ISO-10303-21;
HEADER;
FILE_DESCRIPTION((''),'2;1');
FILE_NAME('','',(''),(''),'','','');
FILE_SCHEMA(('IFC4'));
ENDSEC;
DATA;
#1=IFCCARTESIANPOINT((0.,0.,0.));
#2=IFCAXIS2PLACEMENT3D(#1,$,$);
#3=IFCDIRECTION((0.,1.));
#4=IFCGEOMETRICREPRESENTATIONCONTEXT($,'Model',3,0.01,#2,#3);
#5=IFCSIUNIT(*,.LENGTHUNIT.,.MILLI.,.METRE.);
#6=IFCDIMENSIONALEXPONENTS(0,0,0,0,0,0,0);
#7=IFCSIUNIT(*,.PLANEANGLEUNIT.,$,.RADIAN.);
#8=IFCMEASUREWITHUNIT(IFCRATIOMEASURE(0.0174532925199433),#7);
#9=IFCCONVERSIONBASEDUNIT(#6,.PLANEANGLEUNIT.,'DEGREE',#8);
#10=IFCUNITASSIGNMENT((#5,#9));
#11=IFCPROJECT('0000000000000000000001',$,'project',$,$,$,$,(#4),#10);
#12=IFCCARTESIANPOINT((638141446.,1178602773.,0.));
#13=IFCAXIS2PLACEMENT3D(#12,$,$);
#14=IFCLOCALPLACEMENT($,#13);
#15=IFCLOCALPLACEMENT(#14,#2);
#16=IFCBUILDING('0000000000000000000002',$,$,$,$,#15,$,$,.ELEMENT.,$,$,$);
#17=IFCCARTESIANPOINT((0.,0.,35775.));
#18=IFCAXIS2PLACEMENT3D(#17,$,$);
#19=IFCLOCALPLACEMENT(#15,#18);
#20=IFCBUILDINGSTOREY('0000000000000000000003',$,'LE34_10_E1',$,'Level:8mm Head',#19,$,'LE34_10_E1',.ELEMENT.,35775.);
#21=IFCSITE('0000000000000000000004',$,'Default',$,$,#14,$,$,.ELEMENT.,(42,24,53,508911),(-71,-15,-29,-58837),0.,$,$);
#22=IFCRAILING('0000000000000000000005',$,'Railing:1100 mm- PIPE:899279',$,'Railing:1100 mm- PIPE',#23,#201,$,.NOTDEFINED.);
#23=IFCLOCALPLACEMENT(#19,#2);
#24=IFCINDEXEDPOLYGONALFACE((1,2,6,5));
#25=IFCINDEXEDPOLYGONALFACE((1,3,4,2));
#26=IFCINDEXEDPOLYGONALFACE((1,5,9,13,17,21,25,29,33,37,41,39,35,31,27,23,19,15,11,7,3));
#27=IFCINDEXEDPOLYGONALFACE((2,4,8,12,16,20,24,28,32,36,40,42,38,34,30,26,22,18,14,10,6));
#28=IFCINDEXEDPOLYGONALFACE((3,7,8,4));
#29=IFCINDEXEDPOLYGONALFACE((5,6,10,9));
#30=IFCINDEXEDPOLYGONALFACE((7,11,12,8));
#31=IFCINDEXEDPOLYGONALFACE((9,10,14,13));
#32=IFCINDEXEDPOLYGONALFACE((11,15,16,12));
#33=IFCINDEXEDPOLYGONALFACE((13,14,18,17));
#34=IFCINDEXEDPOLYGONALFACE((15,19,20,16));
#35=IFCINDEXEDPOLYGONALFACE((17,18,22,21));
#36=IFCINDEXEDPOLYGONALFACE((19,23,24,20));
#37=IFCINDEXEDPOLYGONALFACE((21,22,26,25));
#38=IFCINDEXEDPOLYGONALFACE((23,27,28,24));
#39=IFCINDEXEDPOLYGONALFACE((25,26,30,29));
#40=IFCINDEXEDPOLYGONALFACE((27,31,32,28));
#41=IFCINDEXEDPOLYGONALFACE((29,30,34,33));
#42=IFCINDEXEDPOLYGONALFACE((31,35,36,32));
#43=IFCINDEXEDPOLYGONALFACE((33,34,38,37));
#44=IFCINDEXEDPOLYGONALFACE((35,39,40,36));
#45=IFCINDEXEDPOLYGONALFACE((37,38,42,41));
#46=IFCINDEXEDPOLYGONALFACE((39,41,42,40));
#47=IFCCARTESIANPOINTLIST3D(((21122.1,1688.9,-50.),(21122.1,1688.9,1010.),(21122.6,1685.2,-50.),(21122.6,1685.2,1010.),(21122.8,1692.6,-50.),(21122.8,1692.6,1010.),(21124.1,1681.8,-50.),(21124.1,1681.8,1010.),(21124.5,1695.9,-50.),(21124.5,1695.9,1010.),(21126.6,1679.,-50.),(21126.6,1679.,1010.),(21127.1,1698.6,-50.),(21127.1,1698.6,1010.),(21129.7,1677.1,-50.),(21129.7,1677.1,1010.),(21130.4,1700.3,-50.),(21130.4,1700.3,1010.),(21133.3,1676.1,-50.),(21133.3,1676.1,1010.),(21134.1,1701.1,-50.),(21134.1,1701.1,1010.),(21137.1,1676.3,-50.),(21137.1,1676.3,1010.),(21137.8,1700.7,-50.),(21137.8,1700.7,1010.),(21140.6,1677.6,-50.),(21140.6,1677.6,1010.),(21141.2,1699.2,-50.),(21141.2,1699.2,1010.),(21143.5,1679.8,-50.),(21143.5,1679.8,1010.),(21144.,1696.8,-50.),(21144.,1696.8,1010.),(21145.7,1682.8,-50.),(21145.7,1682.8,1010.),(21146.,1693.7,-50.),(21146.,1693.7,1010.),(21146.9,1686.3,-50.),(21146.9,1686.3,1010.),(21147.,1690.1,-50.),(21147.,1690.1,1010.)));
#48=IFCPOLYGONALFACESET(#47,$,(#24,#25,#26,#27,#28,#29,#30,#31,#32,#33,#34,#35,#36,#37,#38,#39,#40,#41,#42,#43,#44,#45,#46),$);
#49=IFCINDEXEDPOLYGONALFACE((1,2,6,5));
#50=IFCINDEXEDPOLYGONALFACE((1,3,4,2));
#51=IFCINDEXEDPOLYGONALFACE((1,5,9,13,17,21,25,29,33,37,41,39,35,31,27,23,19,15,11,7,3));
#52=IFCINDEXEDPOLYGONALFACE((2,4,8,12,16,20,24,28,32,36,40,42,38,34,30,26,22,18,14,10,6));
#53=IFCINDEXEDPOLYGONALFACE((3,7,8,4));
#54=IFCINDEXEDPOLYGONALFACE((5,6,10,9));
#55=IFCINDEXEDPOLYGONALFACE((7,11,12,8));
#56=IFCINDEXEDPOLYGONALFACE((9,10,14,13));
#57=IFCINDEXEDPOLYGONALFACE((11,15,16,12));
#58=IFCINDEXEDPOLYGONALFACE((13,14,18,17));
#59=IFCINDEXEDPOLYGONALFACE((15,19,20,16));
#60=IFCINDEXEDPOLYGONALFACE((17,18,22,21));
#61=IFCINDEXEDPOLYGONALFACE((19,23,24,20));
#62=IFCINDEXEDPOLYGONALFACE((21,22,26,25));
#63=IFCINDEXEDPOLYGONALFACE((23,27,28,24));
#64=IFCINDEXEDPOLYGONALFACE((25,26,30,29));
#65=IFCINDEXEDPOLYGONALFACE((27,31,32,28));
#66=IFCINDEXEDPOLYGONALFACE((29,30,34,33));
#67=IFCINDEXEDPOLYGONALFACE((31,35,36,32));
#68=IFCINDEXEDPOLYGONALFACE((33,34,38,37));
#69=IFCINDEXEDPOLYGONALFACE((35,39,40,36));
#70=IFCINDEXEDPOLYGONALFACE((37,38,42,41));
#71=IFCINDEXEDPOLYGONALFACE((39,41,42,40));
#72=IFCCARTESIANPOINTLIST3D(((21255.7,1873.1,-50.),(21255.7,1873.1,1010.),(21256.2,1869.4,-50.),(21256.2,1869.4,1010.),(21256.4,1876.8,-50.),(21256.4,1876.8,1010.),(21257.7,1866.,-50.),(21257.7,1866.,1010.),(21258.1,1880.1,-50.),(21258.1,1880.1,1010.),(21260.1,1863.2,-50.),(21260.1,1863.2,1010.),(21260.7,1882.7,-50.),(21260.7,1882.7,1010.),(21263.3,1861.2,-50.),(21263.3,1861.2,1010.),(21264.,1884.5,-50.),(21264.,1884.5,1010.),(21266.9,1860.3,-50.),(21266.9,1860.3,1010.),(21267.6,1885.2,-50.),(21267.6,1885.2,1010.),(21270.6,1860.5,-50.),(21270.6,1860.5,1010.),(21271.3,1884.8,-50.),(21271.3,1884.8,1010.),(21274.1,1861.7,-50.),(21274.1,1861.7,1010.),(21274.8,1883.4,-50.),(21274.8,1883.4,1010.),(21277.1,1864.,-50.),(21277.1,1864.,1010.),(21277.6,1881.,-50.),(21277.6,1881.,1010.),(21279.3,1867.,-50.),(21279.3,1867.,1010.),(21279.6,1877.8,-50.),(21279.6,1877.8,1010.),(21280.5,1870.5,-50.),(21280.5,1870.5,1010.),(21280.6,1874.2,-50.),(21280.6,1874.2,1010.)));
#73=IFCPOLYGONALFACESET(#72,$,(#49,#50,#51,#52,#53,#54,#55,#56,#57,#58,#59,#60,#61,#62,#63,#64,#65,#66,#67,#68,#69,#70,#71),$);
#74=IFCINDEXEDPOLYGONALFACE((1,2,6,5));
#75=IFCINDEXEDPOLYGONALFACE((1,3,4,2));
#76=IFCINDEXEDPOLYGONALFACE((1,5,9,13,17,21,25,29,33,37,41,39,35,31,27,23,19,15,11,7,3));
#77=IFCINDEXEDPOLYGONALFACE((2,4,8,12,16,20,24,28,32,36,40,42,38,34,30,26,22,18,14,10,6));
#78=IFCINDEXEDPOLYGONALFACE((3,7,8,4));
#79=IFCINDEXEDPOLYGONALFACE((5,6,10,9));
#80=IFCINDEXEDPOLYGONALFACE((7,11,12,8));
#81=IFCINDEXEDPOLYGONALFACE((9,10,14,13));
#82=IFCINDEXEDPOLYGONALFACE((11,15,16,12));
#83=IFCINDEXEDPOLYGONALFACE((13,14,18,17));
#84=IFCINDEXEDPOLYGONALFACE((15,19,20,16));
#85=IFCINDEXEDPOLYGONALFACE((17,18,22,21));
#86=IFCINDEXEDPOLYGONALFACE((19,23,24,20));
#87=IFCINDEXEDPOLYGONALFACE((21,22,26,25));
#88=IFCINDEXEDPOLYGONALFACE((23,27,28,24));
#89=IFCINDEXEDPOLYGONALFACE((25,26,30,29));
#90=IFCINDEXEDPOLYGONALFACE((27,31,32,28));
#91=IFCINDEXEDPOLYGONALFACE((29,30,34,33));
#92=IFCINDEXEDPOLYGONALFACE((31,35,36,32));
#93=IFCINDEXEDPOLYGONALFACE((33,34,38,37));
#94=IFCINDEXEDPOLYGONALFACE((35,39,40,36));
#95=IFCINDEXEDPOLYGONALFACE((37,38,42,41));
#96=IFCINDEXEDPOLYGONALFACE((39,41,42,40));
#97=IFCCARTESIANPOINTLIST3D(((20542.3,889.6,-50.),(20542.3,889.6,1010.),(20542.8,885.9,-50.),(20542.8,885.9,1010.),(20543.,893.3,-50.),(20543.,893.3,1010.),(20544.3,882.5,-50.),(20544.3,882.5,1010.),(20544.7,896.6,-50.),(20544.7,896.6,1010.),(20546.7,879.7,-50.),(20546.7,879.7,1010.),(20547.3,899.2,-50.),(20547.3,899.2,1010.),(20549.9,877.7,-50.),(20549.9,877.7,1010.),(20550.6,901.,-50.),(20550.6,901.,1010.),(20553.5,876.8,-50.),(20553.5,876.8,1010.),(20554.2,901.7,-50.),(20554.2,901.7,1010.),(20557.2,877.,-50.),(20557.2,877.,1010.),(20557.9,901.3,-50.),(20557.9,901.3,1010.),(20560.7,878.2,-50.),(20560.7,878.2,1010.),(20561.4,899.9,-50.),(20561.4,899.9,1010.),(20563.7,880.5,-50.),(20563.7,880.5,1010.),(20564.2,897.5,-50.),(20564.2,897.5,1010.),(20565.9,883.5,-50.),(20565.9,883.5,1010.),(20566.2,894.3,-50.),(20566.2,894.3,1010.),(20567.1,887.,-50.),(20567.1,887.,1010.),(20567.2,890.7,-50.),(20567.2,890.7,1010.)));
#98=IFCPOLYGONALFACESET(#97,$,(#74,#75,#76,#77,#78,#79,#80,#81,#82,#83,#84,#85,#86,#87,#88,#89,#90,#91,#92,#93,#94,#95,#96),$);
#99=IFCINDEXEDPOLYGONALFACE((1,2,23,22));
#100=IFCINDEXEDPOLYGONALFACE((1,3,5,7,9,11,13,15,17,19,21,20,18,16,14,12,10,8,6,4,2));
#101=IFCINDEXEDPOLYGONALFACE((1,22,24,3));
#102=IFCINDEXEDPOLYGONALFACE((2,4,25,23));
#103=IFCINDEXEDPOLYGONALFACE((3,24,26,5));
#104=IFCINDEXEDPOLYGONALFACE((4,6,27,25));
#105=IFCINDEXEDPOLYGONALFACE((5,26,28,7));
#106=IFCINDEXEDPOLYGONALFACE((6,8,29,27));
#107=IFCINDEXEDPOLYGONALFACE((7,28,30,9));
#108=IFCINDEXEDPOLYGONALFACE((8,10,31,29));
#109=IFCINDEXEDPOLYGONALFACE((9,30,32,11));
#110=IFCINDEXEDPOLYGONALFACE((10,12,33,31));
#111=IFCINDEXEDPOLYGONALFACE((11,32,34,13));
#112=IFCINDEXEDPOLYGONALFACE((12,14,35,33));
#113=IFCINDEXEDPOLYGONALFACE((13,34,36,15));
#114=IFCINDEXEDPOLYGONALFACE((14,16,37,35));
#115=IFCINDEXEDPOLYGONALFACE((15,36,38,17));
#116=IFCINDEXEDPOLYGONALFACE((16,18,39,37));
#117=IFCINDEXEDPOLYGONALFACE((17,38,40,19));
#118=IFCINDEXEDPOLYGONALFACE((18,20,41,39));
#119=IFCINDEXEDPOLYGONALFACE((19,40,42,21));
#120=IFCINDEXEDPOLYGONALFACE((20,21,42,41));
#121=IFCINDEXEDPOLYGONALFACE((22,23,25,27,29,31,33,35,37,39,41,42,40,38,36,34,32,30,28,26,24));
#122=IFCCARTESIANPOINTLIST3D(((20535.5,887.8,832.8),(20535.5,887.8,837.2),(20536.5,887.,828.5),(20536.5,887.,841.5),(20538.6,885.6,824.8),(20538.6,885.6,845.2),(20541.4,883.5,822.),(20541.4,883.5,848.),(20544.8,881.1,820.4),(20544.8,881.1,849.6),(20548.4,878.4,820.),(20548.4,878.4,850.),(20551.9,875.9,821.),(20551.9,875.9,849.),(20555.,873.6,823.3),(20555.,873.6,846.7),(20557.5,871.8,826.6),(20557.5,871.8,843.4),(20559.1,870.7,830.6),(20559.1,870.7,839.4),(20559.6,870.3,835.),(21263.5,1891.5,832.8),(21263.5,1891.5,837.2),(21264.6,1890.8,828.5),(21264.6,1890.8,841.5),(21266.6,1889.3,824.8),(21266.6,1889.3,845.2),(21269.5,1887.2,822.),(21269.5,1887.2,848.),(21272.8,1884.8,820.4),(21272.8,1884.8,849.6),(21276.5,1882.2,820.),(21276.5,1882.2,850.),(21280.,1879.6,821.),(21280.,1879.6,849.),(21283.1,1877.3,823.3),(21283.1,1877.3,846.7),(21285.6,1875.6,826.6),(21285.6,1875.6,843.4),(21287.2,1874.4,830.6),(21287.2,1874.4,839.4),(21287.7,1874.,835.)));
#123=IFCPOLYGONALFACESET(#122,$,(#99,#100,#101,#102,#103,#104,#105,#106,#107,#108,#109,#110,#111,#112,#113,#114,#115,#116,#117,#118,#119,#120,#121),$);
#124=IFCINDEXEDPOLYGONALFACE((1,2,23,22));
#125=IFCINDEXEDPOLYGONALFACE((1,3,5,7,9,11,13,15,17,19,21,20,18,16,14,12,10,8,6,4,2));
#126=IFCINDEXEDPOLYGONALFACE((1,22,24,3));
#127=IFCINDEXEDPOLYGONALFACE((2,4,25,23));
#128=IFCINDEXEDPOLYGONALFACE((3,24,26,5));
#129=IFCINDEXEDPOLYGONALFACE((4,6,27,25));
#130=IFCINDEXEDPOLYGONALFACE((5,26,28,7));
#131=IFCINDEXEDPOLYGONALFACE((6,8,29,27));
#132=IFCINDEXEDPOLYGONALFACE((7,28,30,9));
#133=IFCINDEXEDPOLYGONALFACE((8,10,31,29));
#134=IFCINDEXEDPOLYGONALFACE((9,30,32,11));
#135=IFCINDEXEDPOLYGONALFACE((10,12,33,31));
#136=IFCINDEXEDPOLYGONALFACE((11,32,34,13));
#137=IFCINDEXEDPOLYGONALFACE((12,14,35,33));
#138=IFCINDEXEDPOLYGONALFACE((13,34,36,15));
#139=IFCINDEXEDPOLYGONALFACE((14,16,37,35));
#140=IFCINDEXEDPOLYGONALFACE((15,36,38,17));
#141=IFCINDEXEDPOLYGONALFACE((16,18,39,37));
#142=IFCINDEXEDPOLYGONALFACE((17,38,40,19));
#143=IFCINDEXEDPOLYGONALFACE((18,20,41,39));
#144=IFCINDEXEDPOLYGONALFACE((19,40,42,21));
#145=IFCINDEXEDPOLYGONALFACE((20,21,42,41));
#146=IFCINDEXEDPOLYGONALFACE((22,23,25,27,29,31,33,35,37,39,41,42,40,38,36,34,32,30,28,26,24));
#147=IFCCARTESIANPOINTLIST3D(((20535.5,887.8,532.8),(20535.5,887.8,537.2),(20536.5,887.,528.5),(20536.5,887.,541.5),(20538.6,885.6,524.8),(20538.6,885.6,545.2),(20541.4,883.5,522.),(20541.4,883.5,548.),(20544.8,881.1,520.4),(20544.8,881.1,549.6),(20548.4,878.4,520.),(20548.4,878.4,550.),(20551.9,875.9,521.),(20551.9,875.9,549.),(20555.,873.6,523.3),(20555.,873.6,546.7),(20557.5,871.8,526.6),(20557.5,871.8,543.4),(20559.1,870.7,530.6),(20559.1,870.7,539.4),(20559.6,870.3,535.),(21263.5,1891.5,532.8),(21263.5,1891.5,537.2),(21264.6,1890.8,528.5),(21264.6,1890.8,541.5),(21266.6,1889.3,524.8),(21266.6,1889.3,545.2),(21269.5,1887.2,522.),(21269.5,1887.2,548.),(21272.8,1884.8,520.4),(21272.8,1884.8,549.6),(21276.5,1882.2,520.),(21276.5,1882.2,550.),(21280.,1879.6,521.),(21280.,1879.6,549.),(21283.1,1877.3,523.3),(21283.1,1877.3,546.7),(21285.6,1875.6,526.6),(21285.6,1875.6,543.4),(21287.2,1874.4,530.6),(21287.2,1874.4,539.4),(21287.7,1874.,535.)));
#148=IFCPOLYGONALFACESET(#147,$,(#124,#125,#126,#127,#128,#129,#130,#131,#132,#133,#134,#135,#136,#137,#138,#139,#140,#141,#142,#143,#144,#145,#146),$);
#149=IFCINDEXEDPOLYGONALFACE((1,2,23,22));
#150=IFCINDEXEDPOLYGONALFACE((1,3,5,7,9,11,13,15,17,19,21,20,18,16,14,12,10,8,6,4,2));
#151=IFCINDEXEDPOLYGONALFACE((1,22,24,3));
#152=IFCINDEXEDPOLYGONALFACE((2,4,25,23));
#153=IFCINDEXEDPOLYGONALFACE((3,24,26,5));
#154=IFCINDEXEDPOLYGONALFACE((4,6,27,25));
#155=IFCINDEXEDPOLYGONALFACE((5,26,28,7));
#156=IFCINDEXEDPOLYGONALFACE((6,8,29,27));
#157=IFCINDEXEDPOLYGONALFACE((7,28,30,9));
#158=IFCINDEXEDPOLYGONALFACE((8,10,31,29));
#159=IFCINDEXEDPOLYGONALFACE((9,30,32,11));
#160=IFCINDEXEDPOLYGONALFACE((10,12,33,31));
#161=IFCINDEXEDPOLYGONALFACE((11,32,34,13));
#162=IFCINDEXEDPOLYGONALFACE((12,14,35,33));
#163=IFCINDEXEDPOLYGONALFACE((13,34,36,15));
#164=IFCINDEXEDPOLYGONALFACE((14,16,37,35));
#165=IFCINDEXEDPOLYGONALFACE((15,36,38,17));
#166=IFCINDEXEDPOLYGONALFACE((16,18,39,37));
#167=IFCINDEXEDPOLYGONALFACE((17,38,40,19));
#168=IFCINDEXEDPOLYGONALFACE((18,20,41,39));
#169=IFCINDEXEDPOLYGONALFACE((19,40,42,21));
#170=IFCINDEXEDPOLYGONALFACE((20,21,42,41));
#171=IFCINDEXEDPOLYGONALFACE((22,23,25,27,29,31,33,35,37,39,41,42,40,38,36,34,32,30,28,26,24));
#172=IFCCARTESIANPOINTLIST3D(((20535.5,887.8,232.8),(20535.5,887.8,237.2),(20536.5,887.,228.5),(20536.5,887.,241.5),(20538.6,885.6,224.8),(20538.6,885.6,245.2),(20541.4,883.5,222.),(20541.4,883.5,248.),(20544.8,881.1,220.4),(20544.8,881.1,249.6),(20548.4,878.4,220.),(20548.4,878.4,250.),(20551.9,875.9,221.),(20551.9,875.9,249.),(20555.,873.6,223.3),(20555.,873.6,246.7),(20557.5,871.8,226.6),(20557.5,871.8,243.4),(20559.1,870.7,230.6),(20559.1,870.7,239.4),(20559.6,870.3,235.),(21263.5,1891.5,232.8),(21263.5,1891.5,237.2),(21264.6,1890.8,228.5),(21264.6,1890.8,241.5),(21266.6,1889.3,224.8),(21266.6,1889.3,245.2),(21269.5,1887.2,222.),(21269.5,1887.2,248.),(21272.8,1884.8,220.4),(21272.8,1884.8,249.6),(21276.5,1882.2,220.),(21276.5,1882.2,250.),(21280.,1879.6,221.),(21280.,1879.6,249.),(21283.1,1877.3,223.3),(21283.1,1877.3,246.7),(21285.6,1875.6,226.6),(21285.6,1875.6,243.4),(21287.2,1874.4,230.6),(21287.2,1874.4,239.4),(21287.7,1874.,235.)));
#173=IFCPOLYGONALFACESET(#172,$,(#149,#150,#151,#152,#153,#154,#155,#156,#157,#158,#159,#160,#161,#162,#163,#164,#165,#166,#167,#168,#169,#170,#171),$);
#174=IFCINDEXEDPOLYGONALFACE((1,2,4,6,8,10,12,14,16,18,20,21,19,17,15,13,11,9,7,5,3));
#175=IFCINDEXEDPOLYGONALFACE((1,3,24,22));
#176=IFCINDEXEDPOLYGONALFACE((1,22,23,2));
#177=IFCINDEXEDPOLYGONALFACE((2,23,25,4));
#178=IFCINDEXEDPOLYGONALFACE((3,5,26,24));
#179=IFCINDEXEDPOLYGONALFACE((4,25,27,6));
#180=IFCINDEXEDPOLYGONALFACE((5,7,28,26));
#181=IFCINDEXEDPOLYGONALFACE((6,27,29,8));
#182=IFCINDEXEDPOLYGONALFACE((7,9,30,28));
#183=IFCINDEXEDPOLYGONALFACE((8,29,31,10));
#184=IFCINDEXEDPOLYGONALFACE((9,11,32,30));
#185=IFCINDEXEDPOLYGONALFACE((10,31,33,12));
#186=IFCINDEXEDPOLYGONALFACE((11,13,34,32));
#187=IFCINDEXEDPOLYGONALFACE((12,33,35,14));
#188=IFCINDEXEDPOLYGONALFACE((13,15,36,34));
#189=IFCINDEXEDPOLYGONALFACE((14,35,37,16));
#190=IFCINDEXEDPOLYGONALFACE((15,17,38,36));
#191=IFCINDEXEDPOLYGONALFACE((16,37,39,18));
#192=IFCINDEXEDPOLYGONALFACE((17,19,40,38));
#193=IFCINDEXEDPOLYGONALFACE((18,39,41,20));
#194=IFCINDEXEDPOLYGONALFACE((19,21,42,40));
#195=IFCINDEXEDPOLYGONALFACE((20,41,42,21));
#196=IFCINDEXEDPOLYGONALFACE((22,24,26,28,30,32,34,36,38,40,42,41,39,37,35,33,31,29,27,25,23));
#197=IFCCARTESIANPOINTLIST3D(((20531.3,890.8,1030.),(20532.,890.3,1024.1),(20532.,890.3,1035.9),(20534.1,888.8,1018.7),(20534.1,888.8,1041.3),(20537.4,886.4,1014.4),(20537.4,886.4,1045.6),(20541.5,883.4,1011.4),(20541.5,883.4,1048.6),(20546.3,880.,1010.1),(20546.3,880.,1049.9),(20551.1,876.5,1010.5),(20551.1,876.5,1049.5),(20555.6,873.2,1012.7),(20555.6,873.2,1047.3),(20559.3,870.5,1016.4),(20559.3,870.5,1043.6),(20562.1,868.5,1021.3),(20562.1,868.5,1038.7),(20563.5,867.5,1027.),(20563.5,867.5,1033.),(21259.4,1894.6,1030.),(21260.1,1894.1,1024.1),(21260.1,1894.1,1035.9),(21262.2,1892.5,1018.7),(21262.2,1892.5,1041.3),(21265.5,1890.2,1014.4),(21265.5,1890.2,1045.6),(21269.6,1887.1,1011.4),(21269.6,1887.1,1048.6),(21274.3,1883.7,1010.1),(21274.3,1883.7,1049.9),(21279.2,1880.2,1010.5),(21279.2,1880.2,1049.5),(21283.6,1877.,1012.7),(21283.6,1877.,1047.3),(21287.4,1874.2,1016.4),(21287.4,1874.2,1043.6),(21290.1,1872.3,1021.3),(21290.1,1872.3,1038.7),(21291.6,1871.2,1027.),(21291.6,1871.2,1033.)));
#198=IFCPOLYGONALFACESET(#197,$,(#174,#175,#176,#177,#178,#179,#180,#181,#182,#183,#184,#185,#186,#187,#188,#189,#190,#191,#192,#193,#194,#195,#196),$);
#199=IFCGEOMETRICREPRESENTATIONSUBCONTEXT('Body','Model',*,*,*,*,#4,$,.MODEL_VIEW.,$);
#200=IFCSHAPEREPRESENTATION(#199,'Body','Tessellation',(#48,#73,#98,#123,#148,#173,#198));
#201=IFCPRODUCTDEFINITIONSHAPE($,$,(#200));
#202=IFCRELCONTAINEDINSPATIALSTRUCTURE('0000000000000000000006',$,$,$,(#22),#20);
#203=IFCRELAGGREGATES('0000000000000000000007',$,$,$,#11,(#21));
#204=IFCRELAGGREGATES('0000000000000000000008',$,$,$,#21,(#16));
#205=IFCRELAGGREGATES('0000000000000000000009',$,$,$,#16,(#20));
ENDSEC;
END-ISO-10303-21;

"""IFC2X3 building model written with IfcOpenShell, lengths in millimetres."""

from ifc_helpers import new_model, entity, si_unit, converted_unit, direction, frame, frame_2d, origin, origin_2d_with_axis, place, context, subcontext, project, spatial, circle, extrude, element, save


model = new_model("IFC2X3")

# Units and contexts
model_context = context("Model", 3, precision=0.01, world=origin(), true_north=direction((0.0, 1.0)))
body_context = subcontext(model_context, "Body", "Model", "MODEL_VIEW")
ifc_project = project(units=[si_unit("LENGTHUNIT", "METRE", prefix="MILLI"), converted_unit("PLANEANGLEUNIT", "DEGREE", entity("IfcRatioMeasure", 0.0174532925199433), si_unit("PLANEANGLEUNIT", "RADIAN"), dimensions=[0, 0, 0, 0, 0, 0, 0])], contexts=[model_context])

# Site, building, storey
site_placement = place(None, frame((638141446.0, 1178602773.0, 0.0)))
site = spatial("IfcSite", under=ifc_project, at=site_placement, Name="Default", CompositionType="ELEMENT", RefLatitude=(42, 24, 53, 508911), RefLongitude=(-71, -15, -29, -58837), RefElevation=0.0)
building_placement = place(site_placement, origin())
building = spatial("IfcBuilding", under=site, at=building_placement, CompositionType="ELEMENT")
storey_placement = place(building_placement, frame((0.0, 0.0, 35775.0)))
storey = spatial("IfcBuildingStorey", under=building, at=storey_placement, Name="LE34_10_E1", ObjectType="Level:8mm Head", LongName="LE34_10_E1", CompositionType="ELEMENT", Elevation=35775.0)

# Railing
railing_1_placement = place(storey_placement, origin())
element("IfcRailing", 1, at=railing_1_placement, inside=storey, Name="Railing:1100 mm- PIPE:899279", ObjectType="Railing:1100 mm- PIPE", PredefinedType="NOTDEFINED", context=body_context, shape_type="SweptSolid", body=[
    extrude(circle(Radius=12.5, at=frame_2d((0.0, 0.0), x_axis=(1.0, 0.0))), frame((21134.6, 1688.6, -50.0), z_axis=(0.0, 0.0, 1.0), x_axis=(-0.809468, 0.587164, 0.0)), (0.0, 0.0, 1.0), 1060.0),
    extrude(circle(Radius=12.5, at=origin_2d_with_axis()), frame((21268.2, 1872.7, -50.0), z_axis=(0.0, 0.0, 1.0), x_axis=(-0.809468, 0.587164, 0.0)), (0.0, 0.0, 1.0), 1060.0),
    extrude(circle(Radius=12.5, at=origin_2d_with_axis()), frame((20554.8, 889.2, -50.0), z_axis=(0.0, 0.0, 1.0), x_axis=(-0.809468, 0.587164, 0.0)), (0.0, 0.0, 1.0), 1060.0),
    extrude(circle(Radius=15.0, at=origin_2d_with_axis()), frame((20547.5, 879.1, 835.0), z_axis=(0.587164, 0.809468, 0.0), x_axis=(0.809468, -0.587164, 0.0)), (0.0, 0.0, 1.0), 1240.0),
    extrude(circle(Radius=15.0, at=origin_2d_with_axis()), frame((20547.5, 879.1, 535.0), z_axis=(0.587164, 0.809468, 0.0), x_axis=(0.809468, -0.587164, 0.0)), (0.0, 0.0, 1.0), 1240.0),
    extrude(circle(Radius=15.0, at=origin_2d_with_axis()), frame((20547.5, 879.1, 235.0), z_axis=(0.587164, 0.809468, 0.0), x_axis=(0.809468, -0.587164, 0.0)), (0.0, 0.0, 1.0), 1240.0),
    extrude(circle(Radius=20.0, at=frame_2d((0.0, 0.0), x_axis=(1.0, 0.0))), frame((20547.5, 879.1, 1030.0), z_axis=(0.587164, 0.809468, 0.0), x_axis=(-0.809468, 0.587164, 0.0)), (0.0, 0.0, 1.0), 1240.0),
])

save(model, "model.ifc")
